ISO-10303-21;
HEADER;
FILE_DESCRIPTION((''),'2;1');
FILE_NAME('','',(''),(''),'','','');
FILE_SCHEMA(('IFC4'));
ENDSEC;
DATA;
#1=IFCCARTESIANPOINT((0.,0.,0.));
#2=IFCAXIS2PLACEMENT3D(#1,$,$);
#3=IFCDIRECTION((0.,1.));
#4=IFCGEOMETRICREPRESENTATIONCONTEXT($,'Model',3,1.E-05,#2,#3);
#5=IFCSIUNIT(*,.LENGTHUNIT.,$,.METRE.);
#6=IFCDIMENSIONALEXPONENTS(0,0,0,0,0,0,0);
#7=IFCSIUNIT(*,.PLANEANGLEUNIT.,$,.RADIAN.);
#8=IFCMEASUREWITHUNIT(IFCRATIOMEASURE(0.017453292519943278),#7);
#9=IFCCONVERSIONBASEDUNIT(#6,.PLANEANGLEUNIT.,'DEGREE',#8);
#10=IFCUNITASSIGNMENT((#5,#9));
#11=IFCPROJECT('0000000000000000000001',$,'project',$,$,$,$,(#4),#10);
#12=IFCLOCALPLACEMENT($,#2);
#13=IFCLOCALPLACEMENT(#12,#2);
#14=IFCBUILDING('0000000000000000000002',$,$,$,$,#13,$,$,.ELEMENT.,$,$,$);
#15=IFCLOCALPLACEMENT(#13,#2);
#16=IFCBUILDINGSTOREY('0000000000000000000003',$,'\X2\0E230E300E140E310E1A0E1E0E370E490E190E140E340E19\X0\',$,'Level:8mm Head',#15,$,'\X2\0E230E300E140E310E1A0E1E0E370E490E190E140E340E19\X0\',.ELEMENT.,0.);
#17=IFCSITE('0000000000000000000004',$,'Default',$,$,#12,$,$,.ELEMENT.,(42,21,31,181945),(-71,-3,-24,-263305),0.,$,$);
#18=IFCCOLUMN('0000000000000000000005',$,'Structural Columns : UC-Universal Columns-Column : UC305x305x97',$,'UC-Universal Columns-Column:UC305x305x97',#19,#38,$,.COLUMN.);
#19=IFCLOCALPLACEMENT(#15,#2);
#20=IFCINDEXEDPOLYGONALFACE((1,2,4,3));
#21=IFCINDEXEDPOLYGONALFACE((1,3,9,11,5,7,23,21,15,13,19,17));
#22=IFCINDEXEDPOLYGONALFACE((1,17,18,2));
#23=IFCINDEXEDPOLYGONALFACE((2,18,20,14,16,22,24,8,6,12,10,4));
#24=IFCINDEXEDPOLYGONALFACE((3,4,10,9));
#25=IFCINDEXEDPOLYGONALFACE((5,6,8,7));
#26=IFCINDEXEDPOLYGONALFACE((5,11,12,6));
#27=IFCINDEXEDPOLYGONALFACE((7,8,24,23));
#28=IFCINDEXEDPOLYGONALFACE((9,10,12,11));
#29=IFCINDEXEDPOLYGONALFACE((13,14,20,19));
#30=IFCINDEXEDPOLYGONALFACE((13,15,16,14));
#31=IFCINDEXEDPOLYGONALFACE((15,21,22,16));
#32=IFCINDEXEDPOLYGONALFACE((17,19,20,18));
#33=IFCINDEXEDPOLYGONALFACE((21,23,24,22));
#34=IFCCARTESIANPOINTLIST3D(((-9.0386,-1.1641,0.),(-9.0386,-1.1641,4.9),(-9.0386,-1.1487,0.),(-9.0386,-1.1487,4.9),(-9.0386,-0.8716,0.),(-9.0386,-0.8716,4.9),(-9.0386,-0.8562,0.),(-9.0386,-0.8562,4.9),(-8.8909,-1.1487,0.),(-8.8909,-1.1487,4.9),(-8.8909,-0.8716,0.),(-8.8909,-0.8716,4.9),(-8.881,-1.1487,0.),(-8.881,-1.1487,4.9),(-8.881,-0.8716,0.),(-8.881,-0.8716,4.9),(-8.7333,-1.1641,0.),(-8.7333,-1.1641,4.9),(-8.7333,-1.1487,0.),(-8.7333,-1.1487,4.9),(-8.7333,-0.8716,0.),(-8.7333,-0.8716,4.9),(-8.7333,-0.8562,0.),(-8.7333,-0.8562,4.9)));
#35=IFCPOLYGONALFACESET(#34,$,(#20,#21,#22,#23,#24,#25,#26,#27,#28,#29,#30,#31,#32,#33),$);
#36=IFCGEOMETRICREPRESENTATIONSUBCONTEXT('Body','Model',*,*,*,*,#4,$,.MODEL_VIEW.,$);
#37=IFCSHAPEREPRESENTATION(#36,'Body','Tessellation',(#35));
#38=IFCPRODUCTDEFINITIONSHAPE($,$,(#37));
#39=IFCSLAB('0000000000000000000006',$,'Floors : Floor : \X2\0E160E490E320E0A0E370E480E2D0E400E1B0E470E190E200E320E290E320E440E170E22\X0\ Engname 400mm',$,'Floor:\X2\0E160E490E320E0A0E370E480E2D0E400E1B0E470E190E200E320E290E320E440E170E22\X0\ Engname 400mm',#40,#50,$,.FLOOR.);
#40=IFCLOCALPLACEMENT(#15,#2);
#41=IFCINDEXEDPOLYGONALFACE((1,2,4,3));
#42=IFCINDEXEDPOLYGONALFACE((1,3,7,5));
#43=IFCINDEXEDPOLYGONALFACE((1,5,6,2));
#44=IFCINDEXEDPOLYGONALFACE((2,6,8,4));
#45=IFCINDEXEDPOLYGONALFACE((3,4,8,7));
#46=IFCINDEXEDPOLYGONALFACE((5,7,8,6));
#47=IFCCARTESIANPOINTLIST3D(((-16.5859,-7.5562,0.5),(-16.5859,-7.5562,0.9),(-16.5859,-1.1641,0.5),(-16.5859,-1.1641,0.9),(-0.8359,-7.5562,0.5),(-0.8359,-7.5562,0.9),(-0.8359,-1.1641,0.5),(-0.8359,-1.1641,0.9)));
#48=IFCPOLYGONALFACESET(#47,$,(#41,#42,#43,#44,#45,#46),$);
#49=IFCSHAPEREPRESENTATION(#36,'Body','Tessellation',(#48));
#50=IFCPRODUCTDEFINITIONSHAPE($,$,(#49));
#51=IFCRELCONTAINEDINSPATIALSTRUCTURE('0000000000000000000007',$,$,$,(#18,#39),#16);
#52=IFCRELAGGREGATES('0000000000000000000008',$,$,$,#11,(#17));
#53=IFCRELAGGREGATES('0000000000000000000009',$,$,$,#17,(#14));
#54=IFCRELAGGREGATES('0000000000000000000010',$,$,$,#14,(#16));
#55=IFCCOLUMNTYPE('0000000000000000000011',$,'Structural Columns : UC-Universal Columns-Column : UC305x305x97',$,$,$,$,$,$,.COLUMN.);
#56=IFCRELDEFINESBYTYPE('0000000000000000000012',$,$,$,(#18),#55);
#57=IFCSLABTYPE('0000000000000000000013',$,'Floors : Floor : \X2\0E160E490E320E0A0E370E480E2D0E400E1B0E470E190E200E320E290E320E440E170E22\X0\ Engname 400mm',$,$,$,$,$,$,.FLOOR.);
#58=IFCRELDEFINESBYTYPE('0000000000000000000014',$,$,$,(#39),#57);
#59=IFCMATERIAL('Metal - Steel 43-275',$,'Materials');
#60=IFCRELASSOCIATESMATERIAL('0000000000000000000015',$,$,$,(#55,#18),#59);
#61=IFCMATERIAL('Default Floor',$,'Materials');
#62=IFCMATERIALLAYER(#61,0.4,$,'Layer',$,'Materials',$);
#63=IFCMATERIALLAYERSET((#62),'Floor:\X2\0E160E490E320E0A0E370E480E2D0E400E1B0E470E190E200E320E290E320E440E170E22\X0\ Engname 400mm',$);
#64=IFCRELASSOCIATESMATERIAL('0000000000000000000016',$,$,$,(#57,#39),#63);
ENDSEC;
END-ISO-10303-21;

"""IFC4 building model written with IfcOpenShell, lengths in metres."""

from ifc_helpers import new_model, entity, si_unit, converted_unit, direction, frame, frame_2d, origin, place, context, subcontext, project, spatial, polyline, circle_curve, parameter, trimmed, segment, composite_curve, rectangle, i_section, outline, extrude, source, transform, mapped, material, layer, layer_set, layer_usage, material_profile, profile_set, profile_usage, type_object, type_shapes, element, save


model = new_model("IFC4")

# Units and contexts
model_context = context("Model", 3, precision=1e-05, world=origin(), true_north=direction((0.0, 1.0)))
body_context = subcontext(model_context, "Body", "Model", "MODEL_VIEW")
ifc_project = project(units=[si_unit("LENGTHUNIT", "METRE"), converted_unit("PLANEANGLEUNIT", "DEGREE", entity("IfcRatioMeasure", 0.017453292519943278), si_unit("PLANEANGLEUNIT", "RADIAN"), dimensions=[0, 0, 0, 0, 0, 0, 0])], contexts=[model_context])

# Site, building, storey
site_placement = place(None, origin())
site = spatial("IfcSite", under=ifc_project, at=site_placement, Name="Default", CompositionType="ELEMENT", RefLatitude=(42, 21, 31, 181945), RefLongitude=(-71, -3, -24, -263305), RefElevation=0.0)
building_placement = place(site_placement, origin())
building = spatial("IfcBuilding", under=site, at=building_placement, CompositionType="ELEMENT")
storey_placement = place(building_placement, origin())
storey = spatial("IfcBuildingStorey", under=building, at=storey_placement, Name="ระดับพื้นดิน", ObjectType="Level:8mm Head", LongName="ระดับพื้นดิน", CompositionType="ELEMENT", Elevation=0.0)

# Column
ifc_material_1 = material(Name="Metal - Steel 43-275", Category="Materials")
ifc_material_profile_1 = material_profile(ifc_material_1, outline(composite_curve([segment(polyline([(-0.1527, 0.154, 0.0), (0.1526, 0.154, 0.0)]), True, "CONTINUOUS"), segment(polyline([(0.1526, 0.154, 0.0), (0.1526, 0.1386, 0.0)]), True, "CONTINUOUS"), segment(polyline([(0.1526, 0.1386, 0.0), (0.0201, 0.1386, 0.0)]), True, "CONTINUOUS"), segment(trimmed(circle_curve(frame((0.0201, 0.1234, 0.0)), 0.0152), [parameter(90.0)], [parameter(180.0)], True, "PARAMETER"), True, "CONTINUOUS"), segment(polyline([(0.0049, 0.1233, 0.0), (0.0049, -0.1234, 0.0)]), True, "CONTINUOUS"), segment(trimmed(circle_curve(frame((0.0201, -0.1233, 0.0)), 0.0152), [parameter(180.0)], [parameter(270.0)], True, "PARAMETER"), True, "CONTINUOUS"), segment(polyline([(0.0201, -0.1385, 0.0), (0.1526, -0.1385, 0.0)]), True, "CONTINUOUS"), segment(polyline([(0.1526, -0.1385, 0.0), (0.1526, -0.1539, 0.0)]), True, "CONTINUOUS"), segment(polyline([(0.1526, -0.1539, 0.0), (-0.1527, -0.1539, 0.0)]), True, "CONTINUOUS"), segment(polyline([(-0.1527, -0.1539, 0.0), (-0.1527, -0.1385, 0.0)]), True, "CONTINUOUS"), segment(polyline([(-0.1527, -0.1385, 0.0), (-0.0202, -0.1385, 0.0)]), True, "CONTINUOUS"), segment(trimmed(circle_curve(frame((-0.0202, -0.1233, 0.0)), 0.0152), [parameter(270.0)], [parameter(0.0)], True, "PARAMETER"), True, "CONTINUOUS"), segment(polyline([(-0.005, -0.1233, 0.0), (-0.005, 0.1234, 0.0)]), True, "CONTINUOUS"), segment(trimmed(circle_curve(frame((-0.0202, 0.1234, 0.0)), 0.0152), [parameter(0.0)], [parameter(90.0)], True, "PARAMETER"), True, "CONTINUOUS"), segment(polyline([(-0.0202, 0.1386, 0.0), (-0.1527, 0.1386, 0.0)]), True, "CONTINUOUS"), segment(polyline([(-0.1527, 0.1386, 0.0), (-0.1527, 0.154, 0.0)]), True, "CONTINUOUS")], self_intersect=False), kind="CURVE"), Name="UC305x305x97")
ifc_material_profile_2 = material_profile(ifc_material_1, outline(composite_curve([segment(polyline([(0.1526, 0.154, 4.9), (-0.1527, 0.154, 4.9)]), True, "CONTINUOUS"), segment(polyline([(-0.1527, 0.154, 4.9), (-0.1527, 0.1386, 4.9)]), True, "CONTINUOUS"), segment(polyline([(-0.1527, 0.1386, 4.9), (-0.005, 0.1386, 4.9)]), True, "CONTINUOUS"), segment(polyline([(-0.005, 0.1386, 4.9), (-0.005, -0.1385, 4.9)]), True, "CONTINUOUS"), segment(polyline([(-0.005, -0.1385, 4.9), (-0.1527, -0.1385, 4.9)]), True, "CONTINUOUS"), segment(polyline([(-0.1527, -0.1385, 4.9), (-0.1527, -0.1539, 4.9)]), True, "CONTINUOUS"), segment(polyline([(-0.1527, -0.1539, 4.9), (0.1526, -0.1539, 4.9)]), True, "CONTINUOUS"), segment(polyline([(0.1526, -0.1539, 4.9), (0.1526, -0.1385, 4.9)]), True, "CONTINUOUS"), segment(polyline([(0.1526, -0.1385, 4.9), (0.0049, -0.1385, 4.9)]), True, "CONTINUOUS"), segment(polyline([(0.0049, -0.1385, 4.9), (0.0049, 0.1386, 4.9)]), True, "CONTINUOUS"), segment(polyline([(0.0049, 0.1386, 4.9), (0.1526, 0.1386, 4.9)]), True, "CONTINUOUS"), segment(polyline([(0.1526, 0.1386, 4.9), (0.1526, 0.154, 4.9)]), True, "CONTINUOUS")], self_intersect=False), kind="CURVE"), Name="UC305x305x97")
ifc_profile_set = profile_set([ifc_material_profile_1, ifc_material_profile_2], Name="UC305x305x97")
column_type_1 = type_object("IfcColumnType", Name="Structural Columns : UC-Universal Columns-Column : UC305x305x97", PredefinedType="COLUMN", material=ifc_profile_set)
shared_shape_1 = source(origin(), body_context, "Body", "SweptSolid", [
    extrude(i_section(OverallWidth=0.3053, OverallDepth=0.3079, WebThickness=0.0099, FlangeThickness=0.0154, at=frame_2d((0.0, 0.0), x_axis=(0.0, 1.0))), frame((0.0, 0.0, 0.0), z_axis=(0.0, 0.0, 1.0), x_axis=(0.0, -1.0, 0.0)), (0.0, 0.0, 1.0), 4.9),
])
type_shapes(column_type_1, [shared_shape_1])
ifc_profile_usage_1 = profile_usage(ifc_profile_set)
column_1_placement = place(storey_placement, frame((-8.8859, -1.0102, 0.0)))
element("IfcColumn", 1, at=column_1_placement, inside=storey, type_object=column_type_1, material=ifc_profile_usage_1, Name="Structural Columns : UC-Universal Columns-Column : UC305x305x97", ObjectType="UC-Universal Columns-Column:UC305x305x97", PredefinedType="COLUMN", context=body_context, shape_type="MappedRepresentation", body=[
    mapped(shared_shape_1, transform((0.0, 0.0, 0.0), scale=1.0)),
])

# Slab
ifc_material_2 = material(Name="Default Floor", Category="Materials")
ifc_layer = layer(ifc_material_2, 0.4, Name="Layer", Category="Materials")
ifc_layer_set = layer_set([ifc_layer], Name="Floor:ถ้าชื่อเป็นภาษาไทย Engname 400mm")
ifc_layer_usage = layer_usage(ifc_layer_set, "AXIS3", "POSITIVE", 0.0)
slab_type = type_object("IfcSlabType", Name="Floors : Floor : ถ้าชื่อเป็นภาษาไทย Engname 400mm", PredefinedType="FLOOR", material=ifc_layer_set)
slab_placement = place(storey_placement, origin())
element("IfcSlab", 2, at=slab_placement, inside=storey, type_object=slab_type, material=ifc_layer_usage, Name="Floors : Floor : ถ้าชื่อเป็นภาษาไทย Engname 400mm", ObjectType="Floor:ถ้าชื่อเป็นภาษาไทย Engname 400mm", PredefinedType="FLOOR", context=body_context, shape_type="SweptSolid", body=[
    extrude(rectangle(XDim=6.3921, YDim=15.75, at=frame_2d((0.0, 0.0), x_axis=(1.0, 0.0))), frame((-8.7109, -4.3602, 0.9), z_axis=(0.0, 0.0, -1.0), x_axis=(0.0, 1.0, 0.0)), (0.0, 0.0, 1.0), 0.4),
])

save(model, "model.ifc")
